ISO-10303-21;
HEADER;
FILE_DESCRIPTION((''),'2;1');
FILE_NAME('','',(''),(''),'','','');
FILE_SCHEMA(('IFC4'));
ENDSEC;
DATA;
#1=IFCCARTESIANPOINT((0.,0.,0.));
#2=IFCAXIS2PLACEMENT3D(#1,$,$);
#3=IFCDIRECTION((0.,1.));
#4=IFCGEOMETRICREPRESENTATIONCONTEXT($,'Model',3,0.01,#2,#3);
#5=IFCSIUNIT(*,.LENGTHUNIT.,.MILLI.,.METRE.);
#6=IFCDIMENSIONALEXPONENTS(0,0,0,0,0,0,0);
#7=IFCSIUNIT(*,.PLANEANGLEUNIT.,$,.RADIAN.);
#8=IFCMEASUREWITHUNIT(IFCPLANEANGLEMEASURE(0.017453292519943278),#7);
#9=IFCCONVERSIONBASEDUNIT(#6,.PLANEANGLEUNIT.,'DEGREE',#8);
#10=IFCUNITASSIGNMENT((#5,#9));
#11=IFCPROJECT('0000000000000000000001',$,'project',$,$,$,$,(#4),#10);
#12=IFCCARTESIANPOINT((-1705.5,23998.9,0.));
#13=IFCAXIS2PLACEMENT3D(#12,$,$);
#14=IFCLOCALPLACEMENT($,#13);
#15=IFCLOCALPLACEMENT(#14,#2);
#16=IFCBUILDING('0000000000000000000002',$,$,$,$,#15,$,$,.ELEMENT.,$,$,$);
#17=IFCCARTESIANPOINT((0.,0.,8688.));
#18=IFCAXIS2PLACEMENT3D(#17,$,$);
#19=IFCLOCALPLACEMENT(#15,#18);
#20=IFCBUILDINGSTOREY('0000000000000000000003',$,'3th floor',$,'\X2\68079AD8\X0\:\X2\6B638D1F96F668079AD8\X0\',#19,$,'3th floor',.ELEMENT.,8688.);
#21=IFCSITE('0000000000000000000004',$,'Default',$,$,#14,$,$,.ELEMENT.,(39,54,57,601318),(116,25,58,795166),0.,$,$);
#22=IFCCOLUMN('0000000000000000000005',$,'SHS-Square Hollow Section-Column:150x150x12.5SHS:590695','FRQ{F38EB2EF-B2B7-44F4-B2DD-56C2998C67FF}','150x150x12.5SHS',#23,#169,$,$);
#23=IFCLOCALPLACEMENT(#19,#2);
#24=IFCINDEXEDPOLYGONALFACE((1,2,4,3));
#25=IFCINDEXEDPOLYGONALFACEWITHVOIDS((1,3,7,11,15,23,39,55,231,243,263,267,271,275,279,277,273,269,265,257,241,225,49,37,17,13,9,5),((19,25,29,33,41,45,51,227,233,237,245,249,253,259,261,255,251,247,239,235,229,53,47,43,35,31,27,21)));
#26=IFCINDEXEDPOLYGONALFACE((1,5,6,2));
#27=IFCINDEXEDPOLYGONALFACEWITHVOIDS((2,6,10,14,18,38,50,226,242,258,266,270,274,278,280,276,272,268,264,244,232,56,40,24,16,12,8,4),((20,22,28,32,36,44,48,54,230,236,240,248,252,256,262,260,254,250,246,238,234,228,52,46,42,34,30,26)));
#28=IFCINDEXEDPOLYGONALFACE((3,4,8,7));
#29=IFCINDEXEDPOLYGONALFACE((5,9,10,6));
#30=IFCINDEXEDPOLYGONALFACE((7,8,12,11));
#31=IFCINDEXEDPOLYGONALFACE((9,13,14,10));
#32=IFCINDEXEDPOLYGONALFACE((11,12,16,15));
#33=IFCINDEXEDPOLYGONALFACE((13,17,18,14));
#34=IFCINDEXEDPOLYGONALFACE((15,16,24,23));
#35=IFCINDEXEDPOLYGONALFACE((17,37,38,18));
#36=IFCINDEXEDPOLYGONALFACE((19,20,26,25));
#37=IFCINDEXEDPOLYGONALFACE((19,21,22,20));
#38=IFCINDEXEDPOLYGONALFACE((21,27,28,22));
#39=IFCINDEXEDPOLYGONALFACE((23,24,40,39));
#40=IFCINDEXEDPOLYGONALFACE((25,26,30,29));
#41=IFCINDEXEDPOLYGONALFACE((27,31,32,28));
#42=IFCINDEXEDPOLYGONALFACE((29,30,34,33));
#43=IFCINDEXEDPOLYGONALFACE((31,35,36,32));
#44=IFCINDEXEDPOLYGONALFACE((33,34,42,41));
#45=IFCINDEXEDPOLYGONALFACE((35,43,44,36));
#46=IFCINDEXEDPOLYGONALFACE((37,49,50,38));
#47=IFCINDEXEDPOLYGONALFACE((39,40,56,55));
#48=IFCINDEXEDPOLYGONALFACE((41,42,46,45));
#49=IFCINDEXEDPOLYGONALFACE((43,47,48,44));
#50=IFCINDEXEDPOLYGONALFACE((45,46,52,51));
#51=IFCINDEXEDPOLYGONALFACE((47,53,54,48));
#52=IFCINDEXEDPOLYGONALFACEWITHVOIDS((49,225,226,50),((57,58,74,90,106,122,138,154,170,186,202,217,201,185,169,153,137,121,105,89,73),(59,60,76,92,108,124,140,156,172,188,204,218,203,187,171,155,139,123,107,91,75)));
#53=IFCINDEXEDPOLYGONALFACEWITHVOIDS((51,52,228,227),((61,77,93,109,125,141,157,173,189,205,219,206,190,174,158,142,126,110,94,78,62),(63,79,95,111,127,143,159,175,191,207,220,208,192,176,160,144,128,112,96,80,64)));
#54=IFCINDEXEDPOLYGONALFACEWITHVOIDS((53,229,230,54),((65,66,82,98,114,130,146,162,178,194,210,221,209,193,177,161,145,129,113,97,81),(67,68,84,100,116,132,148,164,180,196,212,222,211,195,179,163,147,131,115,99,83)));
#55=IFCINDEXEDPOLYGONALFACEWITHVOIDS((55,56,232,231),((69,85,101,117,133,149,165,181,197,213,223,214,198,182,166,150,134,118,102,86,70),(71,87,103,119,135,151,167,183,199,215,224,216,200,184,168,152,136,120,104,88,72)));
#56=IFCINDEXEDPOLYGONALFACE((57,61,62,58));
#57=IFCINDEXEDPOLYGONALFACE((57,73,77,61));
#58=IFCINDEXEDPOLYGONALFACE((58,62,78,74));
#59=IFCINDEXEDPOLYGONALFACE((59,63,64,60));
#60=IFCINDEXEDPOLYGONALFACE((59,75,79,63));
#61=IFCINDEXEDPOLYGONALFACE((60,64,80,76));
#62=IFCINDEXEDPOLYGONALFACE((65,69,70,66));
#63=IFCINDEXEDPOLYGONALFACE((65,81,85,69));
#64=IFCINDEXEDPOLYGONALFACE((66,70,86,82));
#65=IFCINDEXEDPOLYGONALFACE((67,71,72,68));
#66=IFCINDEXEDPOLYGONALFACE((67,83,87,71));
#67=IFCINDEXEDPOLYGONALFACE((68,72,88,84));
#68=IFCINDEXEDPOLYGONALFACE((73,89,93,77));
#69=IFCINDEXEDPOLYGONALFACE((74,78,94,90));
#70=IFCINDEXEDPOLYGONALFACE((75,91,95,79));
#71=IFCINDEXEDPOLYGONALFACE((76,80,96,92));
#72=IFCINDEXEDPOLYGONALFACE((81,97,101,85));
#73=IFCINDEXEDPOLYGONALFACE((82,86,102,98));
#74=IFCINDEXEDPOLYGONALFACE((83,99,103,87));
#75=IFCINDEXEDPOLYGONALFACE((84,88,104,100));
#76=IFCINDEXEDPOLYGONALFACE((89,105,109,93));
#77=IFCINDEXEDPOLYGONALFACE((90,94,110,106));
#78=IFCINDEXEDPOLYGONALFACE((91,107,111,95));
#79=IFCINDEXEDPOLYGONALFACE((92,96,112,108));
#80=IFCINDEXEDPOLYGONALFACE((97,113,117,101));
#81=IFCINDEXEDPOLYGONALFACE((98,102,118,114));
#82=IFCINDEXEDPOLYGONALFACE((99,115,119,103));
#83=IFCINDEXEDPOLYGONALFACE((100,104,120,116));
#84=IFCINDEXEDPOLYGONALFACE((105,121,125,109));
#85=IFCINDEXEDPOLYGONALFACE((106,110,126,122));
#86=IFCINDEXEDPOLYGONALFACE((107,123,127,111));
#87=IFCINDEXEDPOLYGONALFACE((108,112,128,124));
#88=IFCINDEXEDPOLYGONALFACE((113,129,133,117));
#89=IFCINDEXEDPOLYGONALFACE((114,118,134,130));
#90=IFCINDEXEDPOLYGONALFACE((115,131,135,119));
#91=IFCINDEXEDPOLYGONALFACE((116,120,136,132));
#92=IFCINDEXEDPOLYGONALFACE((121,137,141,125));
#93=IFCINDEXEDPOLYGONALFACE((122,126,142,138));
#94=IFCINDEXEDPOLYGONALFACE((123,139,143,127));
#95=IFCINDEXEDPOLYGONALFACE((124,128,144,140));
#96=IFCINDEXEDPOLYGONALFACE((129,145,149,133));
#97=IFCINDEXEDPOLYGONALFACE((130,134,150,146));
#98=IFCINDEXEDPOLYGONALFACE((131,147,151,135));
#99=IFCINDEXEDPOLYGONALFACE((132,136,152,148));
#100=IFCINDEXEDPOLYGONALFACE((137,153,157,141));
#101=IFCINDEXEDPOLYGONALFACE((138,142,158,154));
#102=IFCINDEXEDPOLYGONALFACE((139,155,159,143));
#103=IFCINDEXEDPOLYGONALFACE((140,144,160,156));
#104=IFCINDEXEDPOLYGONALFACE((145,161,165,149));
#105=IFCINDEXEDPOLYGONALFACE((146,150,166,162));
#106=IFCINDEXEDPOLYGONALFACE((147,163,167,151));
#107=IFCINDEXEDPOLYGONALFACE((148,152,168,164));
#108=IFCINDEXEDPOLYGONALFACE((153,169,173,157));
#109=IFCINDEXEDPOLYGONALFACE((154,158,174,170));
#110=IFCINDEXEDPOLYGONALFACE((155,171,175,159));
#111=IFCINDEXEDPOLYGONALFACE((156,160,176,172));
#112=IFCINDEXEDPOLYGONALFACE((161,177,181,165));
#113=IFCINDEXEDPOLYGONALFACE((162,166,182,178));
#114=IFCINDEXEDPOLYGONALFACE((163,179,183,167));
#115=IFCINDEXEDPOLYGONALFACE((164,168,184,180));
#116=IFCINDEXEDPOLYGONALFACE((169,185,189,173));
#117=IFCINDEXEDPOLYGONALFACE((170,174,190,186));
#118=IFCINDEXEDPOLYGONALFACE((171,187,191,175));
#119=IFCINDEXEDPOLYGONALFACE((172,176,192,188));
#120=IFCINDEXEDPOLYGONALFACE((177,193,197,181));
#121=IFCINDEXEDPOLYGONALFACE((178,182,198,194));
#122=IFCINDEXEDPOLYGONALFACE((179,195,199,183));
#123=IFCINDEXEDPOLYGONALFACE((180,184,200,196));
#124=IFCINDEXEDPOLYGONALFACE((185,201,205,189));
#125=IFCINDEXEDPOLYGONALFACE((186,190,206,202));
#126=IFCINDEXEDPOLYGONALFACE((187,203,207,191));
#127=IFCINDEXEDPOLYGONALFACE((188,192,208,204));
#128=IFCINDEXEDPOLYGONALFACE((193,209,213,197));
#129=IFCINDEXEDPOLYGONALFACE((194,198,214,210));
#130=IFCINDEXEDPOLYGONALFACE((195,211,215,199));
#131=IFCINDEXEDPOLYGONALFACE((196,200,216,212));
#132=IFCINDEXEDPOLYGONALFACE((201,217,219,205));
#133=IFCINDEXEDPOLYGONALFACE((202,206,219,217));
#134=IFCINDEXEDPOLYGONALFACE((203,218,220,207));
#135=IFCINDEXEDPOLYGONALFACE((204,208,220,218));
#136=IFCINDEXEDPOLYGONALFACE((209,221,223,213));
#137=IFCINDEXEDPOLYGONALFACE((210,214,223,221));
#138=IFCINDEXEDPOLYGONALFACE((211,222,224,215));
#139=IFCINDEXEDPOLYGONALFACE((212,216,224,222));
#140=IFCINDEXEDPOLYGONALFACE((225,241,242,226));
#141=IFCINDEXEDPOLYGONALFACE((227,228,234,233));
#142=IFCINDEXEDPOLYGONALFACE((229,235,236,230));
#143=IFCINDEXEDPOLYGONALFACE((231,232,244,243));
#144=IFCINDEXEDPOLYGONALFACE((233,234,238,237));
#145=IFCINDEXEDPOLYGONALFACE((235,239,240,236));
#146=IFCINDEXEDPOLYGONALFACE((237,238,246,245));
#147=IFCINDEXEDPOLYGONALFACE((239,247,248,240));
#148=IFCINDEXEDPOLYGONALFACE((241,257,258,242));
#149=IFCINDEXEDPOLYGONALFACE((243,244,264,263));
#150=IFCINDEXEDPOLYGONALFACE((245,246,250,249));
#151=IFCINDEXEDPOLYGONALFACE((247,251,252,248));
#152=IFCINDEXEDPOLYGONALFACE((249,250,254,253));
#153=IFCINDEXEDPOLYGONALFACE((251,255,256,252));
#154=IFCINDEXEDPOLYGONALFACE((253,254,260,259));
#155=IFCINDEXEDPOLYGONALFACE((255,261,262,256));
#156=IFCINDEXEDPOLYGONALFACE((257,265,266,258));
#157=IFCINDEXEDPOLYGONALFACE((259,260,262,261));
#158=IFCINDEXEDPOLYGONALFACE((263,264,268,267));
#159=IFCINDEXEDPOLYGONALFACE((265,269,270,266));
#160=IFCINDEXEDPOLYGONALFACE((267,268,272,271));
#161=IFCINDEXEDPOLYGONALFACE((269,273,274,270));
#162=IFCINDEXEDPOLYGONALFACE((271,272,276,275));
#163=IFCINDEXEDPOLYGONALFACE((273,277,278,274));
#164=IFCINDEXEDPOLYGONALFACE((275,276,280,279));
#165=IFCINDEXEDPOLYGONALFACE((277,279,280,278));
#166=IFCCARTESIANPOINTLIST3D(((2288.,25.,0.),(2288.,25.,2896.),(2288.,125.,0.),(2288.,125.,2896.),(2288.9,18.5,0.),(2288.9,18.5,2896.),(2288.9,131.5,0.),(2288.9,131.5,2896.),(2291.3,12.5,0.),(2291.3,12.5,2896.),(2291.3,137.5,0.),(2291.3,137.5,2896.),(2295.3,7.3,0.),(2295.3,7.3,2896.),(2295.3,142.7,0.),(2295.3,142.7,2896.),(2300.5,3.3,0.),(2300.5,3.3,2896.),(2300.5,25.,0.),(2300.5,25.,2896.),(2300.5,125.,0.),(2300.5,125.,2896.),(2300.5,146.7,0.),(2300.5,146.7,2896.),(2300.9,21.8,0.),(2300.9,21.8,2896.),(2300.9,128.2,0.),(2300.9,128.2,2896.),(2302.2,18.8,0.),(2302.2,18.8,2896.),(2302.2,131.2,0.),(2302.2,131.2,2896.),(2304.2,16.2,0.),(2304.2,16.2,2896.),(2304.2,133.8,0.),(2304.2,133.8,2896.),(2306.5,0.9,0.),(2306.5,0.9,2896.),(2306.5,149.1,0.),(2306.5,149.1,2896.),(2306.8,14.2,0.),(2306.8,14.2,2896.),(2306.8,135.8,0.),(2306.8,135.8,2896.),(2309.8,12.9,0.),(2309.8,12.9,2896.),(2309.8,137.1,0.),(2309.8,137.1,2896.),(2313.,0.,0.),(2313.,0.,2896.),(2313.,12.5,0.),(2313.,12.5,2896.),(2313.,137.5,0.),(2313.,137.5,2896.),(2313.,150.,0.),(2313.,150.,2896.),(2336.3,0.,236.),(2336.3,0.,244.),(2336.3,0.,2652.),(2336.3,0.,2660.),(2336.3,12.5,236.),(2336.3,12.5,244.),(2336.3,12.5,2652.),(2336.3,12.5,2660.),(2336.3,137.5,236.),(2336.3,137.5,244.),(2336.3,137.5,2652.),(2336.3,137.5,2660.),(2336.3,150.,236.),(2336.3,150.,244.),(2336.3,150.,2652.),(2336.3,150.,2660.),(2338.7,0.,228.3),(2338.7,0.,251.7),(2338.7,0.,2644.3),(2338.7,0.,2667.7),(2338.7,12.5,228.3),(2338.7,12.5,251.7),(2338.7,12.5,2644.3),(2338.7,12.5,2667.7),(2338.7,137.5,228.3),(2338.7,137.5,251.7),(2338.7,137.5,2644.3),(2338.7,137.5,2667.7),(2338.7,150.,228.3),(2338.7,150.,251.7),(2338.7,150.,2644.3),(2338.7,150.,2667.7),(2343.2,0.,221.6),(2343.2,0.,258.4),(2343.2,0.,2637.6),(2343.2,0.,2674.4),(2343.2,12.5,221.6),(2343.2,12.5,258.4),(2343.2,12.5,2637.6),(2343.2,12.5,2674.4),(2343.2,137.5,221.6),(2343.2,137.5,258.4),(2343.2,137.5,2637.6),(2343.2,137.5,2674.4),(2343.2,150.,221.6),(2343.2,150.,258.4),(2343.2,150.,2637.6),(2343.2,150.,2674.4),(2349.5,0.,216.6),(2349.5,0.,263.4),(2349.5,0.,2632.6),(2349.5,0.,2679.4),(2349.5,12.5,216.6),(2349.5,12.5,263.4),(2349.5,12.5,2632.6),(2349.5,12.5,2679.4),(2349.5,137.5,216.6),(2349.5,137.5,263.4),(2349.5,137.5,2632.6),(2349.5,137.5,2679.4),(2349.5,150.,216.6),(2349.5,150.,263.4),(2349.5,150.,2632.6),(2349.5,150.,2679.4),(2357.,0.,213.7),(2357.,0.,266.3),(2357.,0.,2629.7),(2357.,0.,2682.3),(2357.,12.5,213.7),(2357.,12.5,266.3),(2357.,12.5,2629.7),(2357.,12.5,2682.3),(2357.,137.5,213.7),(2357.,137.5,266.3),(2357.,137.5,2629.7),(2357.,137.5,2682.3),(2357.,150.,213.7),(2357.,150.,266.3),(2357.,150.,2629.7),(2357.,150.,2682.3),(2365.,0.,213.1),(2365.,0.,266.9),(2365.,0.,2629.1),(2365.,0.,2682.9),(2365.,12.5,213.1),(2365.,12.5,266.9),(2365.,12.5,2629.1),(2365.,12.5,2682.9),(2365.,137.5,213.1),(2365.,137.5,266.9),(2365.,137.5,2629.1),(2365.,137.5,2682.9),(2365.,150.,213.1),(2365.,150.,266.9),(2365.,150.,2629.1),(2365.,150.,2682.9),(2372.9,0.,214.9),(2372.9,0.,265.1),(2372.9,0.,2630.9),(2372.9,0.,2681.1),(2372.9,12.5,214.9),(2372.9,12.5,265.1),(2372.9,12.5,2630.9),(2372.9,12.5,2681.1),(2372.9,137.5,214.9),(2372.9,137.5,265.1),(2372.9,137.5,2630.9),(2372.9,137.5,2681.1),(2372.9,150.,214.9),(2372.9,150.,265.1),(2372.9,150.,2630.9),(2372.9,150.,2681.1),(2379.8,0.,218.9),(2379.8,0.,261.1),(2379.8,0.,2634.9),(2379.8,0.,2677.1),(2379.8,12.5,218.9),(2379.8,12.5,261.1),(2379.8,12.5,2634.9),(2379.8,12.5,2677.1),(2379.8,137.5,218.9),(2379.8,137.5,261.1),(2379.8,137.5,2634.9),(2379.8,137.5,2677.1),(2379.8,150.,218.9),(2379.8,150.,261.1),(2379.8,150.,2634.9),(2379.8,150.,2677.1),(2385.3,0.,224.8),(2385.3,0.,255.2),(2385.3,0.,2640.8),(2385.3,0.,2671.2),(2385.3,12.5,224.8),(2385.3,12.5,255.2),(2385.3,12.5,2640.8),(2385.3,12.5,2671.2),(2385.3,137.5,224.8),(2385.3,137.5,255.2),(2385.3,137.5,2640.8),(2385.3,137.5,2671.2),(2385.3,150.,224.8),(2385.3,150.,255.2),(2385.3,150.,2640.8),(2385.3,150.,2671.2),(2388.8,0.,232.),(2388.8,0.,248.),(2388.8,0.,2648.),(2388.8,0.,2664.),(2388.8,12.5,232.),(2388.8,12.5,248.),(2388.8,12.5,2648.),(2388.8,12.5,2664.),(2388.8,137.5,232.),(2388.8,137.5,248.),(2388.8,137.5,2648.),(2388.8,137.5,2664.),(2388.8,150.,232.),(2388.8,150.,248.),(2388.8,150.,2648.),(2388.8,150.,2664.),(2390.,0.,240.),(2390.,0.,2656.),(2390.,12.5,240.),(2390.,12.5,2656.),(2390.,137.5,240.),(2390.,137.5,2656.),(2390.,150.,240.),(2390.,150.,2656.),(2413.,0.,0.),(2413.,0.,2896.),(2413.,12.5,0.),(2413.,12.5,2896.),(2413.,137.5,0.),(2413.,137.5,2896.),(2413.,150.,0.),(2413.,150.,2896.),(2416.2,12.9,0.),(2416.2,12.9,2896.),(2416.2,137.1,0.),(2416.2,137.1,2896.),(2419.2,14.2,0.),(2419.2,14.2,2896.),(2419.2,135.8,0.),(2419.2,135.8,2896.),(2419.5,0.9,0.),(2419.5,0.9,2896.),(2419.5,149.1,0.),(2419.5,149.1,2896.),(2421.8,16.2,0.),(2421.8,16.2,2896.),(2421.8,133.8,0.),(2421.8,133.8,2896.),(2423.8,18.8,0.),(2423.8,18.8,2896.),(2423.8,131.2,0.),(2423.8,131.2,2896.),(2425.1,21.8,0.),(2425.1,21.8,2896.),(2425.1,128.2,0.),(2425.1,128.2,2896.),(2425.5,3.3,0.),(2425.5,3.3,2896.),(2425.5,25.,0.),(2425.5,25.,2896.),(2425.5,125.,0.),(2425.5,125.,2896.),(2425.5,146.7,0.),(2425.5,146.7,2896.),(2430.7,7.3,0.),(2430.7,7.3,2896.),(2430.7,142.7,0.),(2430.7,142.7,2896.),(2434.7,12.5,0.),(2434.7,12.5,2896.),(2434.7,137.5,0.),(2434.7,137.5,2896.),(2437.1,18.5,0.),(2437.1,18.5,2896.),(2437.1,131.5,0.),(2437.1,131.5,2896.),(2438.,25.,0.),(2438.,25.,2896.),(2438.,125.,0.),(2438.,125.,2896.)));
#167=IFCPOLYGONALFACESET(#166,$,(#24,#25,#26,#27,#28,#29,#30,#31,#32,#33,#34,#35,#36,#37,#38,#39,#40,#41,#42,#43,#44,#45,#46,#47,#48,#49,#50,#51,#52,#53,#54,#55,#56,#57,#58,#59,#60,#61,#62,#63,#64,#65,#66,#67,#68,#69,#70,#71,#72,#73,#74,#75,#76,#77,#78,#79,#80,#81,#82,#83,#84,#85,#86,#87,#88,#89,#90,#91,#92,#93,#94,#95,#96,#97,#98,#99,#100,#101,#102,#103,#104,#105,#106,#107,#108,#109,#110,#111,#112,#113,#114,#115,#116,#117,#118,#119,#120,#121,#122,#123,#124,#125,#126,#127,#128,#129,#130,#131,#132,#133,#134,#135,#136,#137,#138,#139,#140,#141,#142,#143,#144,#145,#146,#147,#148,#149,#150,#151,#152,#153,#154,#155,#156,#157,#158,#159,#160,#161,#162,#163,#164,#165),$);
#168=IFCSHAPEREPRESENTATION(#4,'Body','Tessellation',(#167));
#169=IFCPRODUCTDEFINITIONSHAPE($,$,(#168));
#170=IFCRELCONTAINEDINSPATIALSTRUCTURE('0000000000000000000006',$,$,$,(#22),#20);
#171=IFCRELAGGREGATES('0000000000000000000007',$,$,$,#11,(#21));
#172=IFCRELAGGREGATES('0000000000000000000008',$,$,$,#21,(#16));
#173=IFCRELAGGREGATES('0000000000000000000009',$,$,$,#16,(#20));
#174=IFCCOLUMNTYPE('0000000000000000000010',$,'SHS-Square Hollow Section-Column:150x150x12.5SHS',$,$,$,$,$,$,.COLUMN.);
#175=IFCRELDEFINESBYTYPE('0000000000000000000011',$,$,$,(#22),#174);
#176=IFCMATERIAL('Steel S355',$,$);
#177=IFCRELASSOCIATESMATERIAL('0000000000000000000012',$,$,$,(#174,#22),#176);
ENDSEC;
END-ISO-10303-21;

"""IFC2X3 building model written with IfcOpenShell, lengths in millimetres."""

from ifc_helpers import new_model, entity, si_unit, converted_unit, direction, frame, frame_2d, origin, origin_2d, place, context, project, spatial, circle_curve, hollow_rectangle, outline, extrude, material, type_object, element, save


model = new_model("IFC2X3")

# Units and contexts
model_context = context("Model", 3, precision=0.01, world=origin(), true_north=direction((0.0, 1.0)))
ifc_project = project(units=[si_unit("LENGTHUNIT", "METRE", prefix="MILLI"), converted_unit("PLANEANGLEUNIT", "DEGREE", entity("IfcPlaneAngleMeasure", 0.017453292519943278), si_unit("PLANEANGLEUNIT", "RADIAN"), dimensions=[0, 0, 0, 0, 0, 0, 0])], contexts=[model_context])

# Site, building, storey
site_placement = place(None, frame((-1705.5, 23998.9, 0.0)))
site = spatial("IfcSite", under=ifc_project, at=site_placement, Name="Default", CompositionType="ELEMENT", RefLatitude=(39, 54, 57, 601318), RefLongitude=(116, 25, 58, 795166), RefElevation=0.0)
building_placement = place(site_placement, origin())
building = spatial("IfcBuilding", under=site, at=building_placement, CompositionType="ELEMENT")
storey_placement = place(building_placement, frame((0.0, 0.0, 8688.0)))
storey = spatial("IfcBuildingStorey", under=building, at=storey_placement, Name="3th floor", ObjectType="标高:正负零标高", LongName="3th floor", CompositionType="ELEMENT", Elevation=8688.0)

# Column, openings
ifc_material_1 = material(Name="Steel S355")
column_type_1 = type_object("IfcColumnType", Name="SHS-Square Hollow Section-Column:150x150x12.5SHS", PredefinedType="COLUMN", material=ifc_material_1)
column_1_placement = place(storey_placement, frame((2363.0, 75.0, 2896.0), z_axis=(0.0, 0.0, 1.0), x_axis=(0.0, -1.0, 0.0)))
column_1 = element("IfcColumn", 1, at=column_1_placement, inside=storey, type_object=column_type_1, material=ifc_material_1, Name="SHS-Square Hollow Section-Column:150x150x12.5SHS:590695", Description="FRQ{F38EB2EF-B2B7-44F4-B2DD-56C2998C67FF}", ObjectType="150x150x12.5SHS", context=model_context, shape_type="SweptSolid", body=[
    extrude(hollow_rectangle(XDim=150.0, YDim=150.0, WallThickness=12.5, InnerFilletRadius=12.5, OuterFilletRadius=25.0, at=origin_2d()), origin(), (0.0, 0.0, -1.0), 2896.0),
])
opening_1_placement = place(column_1_placement, frame((-175.1, 0.0, 0.0), z_axis=(1.0, 0.0, 0.0), x_axis=(0.0, 1.0, 0.0)))
element("IfcOpeningElement", 2, at=opening_1_placement, cuts=column_1, ObjectType="Opening", context=model_context, shape_type="SweptSolid", body=[
    extrude(outline(circle_curve(frame_2d((0.0, -240.0), x_axis=(1.0, 0.0)), 27.0)), origin(), (0.0, 0.0, 1.0), 350.2),
])
opening_2_placement = place(column_1_placement, frame((-175.1, 0.0, -2896.0), z_axis=(1.0, 0.0, 0.0), x_axis=(0.0, 1.0, 0.0)))
element("IfcOpeningElement", 3, at=opening_2_placement, cuts=column_1, ObjectType="Opening", context=model_context, shape_type="SweptSolid", body=[
    extrude(outline(circle_curve(frame_2d((0.0, 240.0), x_axis=(1.0, 0.0)), 27.0)), origin(), (0.0, 0.0, 1.0), 350.2),
])

save(model, "model.ifc")
